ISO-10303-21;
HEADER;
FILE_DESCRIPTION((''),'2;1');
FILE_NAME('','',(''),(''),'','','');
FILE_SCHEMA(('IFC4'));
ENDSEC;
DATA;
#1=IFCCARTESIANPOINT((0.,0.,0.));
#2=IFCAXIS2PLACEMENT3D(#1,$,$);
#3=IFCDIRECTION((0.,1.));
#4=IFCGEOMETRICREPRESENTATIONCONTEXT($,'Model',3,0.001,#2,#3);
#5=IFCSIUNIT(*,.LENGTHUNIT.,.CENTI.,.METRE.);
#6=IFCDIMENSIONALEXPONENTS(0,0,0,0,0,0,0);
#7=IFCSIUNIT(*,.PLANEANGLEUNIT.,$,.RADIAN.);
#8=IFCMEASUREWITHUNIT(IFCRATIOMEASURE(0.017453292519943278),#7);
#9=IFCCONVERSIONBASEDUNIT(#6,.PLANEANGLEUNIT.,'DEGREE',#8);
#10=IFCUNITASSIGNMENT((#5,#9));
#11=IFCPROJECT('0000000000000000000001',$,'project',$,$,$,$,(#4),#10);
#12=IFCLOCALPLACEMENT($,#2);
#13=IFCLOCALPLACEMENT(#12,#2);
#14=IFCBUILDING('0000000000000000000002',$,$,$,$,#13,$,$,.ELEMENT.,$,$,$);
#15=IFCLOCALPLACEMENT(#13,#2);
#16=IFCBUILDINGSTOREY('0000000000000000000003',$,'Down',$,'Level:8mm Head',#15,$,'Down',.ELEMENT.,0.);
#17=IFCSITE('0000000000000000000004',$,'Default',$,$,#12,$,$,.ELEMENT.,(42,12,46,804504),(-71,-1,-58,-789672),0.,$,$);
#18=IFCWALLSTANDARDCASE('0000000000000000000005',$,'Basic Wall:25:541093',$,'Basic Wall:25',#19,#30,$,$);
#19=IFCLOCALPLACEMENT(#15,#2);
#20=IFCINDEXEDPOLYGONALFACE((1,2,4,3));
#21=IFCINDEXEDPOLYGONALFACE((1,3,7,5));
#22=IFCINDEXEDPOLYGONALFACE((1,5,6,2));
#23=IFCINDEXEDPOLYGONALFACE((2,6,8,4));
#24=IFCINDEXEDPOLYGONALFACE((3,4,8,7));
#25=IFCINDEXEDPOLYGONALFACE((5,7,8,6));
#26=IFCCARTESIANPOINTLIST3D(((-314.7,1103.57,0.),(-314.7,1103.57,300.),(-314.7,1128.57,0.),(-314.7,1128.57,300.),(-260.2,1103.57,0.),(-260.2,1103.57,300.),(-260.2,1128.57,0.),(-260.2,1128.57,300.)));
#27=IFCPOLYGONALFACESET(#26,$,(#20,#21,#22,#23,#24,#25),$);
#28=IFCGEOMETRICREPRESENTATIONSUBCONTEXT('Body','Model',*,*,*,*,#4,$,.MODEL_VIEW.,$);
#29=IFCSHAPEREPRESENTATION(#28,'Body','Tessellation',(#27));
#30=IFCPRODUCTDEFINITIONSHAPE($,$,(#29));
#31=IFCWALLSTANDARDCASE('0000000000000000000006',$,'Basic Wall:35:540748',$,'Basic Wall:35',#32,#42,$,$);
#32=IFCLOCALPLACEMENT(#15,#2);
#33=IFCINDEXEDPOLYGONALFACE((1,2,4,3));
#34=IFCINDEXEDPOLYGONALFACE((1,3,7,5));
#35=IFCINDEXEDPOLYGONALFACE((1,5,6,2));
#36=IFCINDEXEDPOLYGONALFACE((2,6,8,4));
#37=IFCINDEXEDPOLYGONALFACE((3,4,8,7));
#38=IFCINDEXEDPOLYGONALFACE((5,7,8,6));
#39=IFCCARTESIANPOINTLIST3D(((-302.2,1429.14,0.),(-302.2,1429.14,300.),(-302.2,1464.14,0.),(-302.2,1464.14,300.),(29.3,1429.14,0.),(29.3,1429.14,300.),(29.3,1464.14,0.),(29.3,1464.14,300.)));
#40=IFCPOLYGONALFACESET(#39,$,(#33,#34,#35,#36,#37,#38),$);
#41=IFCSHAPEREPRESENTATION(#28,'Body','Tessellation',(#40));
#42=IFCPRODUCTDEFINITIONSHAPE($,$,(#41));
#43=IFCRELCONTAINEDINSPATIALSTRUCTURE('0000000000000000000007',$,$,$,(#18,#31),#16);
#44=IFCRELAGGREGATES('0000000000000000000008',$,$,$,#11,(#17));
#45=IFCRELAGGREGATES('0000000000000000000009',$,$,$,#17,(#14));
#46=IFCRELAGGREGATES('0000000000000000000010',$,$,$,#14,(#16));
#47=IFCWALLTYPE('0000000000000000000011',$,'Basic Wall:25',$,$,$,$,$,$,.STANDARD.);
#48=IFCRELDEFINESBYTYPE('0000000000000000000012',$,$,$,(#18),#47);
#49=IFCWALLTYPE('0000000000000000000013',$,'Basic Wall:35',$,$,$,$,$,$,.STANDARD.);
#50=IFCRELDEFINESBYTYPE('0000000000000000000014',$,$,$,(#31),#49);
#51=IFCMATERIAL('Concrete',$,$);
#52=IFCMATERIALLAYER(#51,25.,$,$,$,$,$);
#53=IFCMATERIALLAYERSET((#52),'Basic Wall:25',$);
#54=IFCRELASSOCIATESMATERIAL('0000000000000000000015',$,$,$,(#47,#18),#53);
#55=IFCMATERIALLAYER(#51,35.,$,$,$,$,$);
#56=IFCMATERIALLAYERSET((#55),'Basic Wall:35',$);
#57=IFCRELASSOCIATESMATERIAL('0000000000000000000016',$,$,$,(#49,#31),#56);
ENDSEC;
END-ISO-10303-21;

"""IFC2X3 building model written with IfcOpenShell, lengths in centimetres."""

from ifc_helpers import new_model, entity, si_unit, converted_unit, direction, frame, frame_2d, origin, place, context, subcontext, project, spatial, rectangle, extrude, material, layer, layer_set, layer_usage, type_object, element, save


model = new_model("IFC2X3")

# Units and contexts
model_context = context("Model", 3, precision=0.001, world=origin(), true_north=direction((0.0, 1.0)))
body_context = subcontext(model_context, "Body", "Model", "MODEL_VIEW")
ifc_project = project(units=[si_unit("LENGTHUNIT", "METRE", prefix="CENTI"), converted_unit("PLANEANGLEUNIT", "DEGREE", entity("IfcRatioMeasure", 0.017453292519943278), si_unit("PLANEANGLEUNIT", "RADIAN"), dimensions=[0, 0, 0, 0, 0, 0, 0])], contexts=[model_context])

# Site, building, storey
site_placement = place(None, origin())
site = spatial("IfcSite", under=ifc_project, at=site_placement, Name="Default", CompositionType="ELEMENT", RefLatitude=(42, 12, 46, 804504), RefLongitude=(-71, -1, -58, -789672), RefElevation=0.0)
building_placement = place(site_placement, origin())
building = spatial("IfcBuilding", under=site, at=building_placement, CompositionType="ELEMENT")
storey_placement = place(building_placement, origin())
storey = spatial("IfcBuildingStorey", under=building, at=storey_placement, Name="Down", ObjectType="Level:8mm Head", LongName="Down", CompositionType="ELEMENT", Elevation=0.0)

# Walls
ifc_material = material(Name="Concrete")
ifc_layer_1 = layer(ifc_material, 25.0)
ifc_layer_set_1 = layer_set([ifc_layer_1], Name="Basic Wall:25")
wall_type_1 = type_object("IfcWallType", Name="Basic Wall:25", PredefinedType="STANDARD", material=ifc_layer_set_1)
ifc_layer_usage_1 = layer_usage(ifc_layer_set_1, "AXIS2", "POSITIVE", -12.5)
wall_1_placement = place(storey_placement, frame((-314.7, 1116.07, 0.0)))
element("IfcWallStandardCase", 1, at=wall_1_placement, inside=storey, type_object=wall_type_1, material=ifc_layer_usage_1, Name="Basic Wall:25:541093", ObjectType="Basic Wall:25", context=body_context, shape_type="SweptSolid", body=[
    extrude(rectangle(XDim=54.5, YDim=25.0, at=frame_2d((27.25, 0.0), x_axis=(-1.0, 0.0))), origin(), (0.0, 0.0, 1.0), 300.0),
])
ifc_layer_2 = layer(ifc_material, 35.0)
ifc_layer_set_2 = layer_set([ifc_layer_2], Name="Basic Wall:35")
ifc_layer_usage_2 = layer_usage(ifc_layer_set_2, "AXIS2", "POSITIVE", -17.5)
wall_type_2 = type_object("IfcWallType", Name="Basic Wall:35", PredefinedType="STANDARD", material=ifc_layer_set_2)
wall_2_placement = place(storey_placement, frame((29.3, 1446.64, 0.0), z_axis=(0.0, 0.0, 1.0), x_axis=(-1.0, 0.0, 0.0)))
element("IfcWallStandardCase", 2, at=wall_2_placement, inside=storey, type_object=wall_type_2, material=ifc_layer_usage_2, Name="Basic Wall:35:540748", ObjectType="Basic Wall:35", context=body_context, shape_type="SweptSolid", body=[
    extrude(rectangle(XDim=331.5, YDim=35.0, at=frame_2d((165.75, 0.0), x_axis=(-1.0, 0.0))), origin(), (0.0, 0.0, 1.0), 300.0),
])

save(model, "model.ifc")
